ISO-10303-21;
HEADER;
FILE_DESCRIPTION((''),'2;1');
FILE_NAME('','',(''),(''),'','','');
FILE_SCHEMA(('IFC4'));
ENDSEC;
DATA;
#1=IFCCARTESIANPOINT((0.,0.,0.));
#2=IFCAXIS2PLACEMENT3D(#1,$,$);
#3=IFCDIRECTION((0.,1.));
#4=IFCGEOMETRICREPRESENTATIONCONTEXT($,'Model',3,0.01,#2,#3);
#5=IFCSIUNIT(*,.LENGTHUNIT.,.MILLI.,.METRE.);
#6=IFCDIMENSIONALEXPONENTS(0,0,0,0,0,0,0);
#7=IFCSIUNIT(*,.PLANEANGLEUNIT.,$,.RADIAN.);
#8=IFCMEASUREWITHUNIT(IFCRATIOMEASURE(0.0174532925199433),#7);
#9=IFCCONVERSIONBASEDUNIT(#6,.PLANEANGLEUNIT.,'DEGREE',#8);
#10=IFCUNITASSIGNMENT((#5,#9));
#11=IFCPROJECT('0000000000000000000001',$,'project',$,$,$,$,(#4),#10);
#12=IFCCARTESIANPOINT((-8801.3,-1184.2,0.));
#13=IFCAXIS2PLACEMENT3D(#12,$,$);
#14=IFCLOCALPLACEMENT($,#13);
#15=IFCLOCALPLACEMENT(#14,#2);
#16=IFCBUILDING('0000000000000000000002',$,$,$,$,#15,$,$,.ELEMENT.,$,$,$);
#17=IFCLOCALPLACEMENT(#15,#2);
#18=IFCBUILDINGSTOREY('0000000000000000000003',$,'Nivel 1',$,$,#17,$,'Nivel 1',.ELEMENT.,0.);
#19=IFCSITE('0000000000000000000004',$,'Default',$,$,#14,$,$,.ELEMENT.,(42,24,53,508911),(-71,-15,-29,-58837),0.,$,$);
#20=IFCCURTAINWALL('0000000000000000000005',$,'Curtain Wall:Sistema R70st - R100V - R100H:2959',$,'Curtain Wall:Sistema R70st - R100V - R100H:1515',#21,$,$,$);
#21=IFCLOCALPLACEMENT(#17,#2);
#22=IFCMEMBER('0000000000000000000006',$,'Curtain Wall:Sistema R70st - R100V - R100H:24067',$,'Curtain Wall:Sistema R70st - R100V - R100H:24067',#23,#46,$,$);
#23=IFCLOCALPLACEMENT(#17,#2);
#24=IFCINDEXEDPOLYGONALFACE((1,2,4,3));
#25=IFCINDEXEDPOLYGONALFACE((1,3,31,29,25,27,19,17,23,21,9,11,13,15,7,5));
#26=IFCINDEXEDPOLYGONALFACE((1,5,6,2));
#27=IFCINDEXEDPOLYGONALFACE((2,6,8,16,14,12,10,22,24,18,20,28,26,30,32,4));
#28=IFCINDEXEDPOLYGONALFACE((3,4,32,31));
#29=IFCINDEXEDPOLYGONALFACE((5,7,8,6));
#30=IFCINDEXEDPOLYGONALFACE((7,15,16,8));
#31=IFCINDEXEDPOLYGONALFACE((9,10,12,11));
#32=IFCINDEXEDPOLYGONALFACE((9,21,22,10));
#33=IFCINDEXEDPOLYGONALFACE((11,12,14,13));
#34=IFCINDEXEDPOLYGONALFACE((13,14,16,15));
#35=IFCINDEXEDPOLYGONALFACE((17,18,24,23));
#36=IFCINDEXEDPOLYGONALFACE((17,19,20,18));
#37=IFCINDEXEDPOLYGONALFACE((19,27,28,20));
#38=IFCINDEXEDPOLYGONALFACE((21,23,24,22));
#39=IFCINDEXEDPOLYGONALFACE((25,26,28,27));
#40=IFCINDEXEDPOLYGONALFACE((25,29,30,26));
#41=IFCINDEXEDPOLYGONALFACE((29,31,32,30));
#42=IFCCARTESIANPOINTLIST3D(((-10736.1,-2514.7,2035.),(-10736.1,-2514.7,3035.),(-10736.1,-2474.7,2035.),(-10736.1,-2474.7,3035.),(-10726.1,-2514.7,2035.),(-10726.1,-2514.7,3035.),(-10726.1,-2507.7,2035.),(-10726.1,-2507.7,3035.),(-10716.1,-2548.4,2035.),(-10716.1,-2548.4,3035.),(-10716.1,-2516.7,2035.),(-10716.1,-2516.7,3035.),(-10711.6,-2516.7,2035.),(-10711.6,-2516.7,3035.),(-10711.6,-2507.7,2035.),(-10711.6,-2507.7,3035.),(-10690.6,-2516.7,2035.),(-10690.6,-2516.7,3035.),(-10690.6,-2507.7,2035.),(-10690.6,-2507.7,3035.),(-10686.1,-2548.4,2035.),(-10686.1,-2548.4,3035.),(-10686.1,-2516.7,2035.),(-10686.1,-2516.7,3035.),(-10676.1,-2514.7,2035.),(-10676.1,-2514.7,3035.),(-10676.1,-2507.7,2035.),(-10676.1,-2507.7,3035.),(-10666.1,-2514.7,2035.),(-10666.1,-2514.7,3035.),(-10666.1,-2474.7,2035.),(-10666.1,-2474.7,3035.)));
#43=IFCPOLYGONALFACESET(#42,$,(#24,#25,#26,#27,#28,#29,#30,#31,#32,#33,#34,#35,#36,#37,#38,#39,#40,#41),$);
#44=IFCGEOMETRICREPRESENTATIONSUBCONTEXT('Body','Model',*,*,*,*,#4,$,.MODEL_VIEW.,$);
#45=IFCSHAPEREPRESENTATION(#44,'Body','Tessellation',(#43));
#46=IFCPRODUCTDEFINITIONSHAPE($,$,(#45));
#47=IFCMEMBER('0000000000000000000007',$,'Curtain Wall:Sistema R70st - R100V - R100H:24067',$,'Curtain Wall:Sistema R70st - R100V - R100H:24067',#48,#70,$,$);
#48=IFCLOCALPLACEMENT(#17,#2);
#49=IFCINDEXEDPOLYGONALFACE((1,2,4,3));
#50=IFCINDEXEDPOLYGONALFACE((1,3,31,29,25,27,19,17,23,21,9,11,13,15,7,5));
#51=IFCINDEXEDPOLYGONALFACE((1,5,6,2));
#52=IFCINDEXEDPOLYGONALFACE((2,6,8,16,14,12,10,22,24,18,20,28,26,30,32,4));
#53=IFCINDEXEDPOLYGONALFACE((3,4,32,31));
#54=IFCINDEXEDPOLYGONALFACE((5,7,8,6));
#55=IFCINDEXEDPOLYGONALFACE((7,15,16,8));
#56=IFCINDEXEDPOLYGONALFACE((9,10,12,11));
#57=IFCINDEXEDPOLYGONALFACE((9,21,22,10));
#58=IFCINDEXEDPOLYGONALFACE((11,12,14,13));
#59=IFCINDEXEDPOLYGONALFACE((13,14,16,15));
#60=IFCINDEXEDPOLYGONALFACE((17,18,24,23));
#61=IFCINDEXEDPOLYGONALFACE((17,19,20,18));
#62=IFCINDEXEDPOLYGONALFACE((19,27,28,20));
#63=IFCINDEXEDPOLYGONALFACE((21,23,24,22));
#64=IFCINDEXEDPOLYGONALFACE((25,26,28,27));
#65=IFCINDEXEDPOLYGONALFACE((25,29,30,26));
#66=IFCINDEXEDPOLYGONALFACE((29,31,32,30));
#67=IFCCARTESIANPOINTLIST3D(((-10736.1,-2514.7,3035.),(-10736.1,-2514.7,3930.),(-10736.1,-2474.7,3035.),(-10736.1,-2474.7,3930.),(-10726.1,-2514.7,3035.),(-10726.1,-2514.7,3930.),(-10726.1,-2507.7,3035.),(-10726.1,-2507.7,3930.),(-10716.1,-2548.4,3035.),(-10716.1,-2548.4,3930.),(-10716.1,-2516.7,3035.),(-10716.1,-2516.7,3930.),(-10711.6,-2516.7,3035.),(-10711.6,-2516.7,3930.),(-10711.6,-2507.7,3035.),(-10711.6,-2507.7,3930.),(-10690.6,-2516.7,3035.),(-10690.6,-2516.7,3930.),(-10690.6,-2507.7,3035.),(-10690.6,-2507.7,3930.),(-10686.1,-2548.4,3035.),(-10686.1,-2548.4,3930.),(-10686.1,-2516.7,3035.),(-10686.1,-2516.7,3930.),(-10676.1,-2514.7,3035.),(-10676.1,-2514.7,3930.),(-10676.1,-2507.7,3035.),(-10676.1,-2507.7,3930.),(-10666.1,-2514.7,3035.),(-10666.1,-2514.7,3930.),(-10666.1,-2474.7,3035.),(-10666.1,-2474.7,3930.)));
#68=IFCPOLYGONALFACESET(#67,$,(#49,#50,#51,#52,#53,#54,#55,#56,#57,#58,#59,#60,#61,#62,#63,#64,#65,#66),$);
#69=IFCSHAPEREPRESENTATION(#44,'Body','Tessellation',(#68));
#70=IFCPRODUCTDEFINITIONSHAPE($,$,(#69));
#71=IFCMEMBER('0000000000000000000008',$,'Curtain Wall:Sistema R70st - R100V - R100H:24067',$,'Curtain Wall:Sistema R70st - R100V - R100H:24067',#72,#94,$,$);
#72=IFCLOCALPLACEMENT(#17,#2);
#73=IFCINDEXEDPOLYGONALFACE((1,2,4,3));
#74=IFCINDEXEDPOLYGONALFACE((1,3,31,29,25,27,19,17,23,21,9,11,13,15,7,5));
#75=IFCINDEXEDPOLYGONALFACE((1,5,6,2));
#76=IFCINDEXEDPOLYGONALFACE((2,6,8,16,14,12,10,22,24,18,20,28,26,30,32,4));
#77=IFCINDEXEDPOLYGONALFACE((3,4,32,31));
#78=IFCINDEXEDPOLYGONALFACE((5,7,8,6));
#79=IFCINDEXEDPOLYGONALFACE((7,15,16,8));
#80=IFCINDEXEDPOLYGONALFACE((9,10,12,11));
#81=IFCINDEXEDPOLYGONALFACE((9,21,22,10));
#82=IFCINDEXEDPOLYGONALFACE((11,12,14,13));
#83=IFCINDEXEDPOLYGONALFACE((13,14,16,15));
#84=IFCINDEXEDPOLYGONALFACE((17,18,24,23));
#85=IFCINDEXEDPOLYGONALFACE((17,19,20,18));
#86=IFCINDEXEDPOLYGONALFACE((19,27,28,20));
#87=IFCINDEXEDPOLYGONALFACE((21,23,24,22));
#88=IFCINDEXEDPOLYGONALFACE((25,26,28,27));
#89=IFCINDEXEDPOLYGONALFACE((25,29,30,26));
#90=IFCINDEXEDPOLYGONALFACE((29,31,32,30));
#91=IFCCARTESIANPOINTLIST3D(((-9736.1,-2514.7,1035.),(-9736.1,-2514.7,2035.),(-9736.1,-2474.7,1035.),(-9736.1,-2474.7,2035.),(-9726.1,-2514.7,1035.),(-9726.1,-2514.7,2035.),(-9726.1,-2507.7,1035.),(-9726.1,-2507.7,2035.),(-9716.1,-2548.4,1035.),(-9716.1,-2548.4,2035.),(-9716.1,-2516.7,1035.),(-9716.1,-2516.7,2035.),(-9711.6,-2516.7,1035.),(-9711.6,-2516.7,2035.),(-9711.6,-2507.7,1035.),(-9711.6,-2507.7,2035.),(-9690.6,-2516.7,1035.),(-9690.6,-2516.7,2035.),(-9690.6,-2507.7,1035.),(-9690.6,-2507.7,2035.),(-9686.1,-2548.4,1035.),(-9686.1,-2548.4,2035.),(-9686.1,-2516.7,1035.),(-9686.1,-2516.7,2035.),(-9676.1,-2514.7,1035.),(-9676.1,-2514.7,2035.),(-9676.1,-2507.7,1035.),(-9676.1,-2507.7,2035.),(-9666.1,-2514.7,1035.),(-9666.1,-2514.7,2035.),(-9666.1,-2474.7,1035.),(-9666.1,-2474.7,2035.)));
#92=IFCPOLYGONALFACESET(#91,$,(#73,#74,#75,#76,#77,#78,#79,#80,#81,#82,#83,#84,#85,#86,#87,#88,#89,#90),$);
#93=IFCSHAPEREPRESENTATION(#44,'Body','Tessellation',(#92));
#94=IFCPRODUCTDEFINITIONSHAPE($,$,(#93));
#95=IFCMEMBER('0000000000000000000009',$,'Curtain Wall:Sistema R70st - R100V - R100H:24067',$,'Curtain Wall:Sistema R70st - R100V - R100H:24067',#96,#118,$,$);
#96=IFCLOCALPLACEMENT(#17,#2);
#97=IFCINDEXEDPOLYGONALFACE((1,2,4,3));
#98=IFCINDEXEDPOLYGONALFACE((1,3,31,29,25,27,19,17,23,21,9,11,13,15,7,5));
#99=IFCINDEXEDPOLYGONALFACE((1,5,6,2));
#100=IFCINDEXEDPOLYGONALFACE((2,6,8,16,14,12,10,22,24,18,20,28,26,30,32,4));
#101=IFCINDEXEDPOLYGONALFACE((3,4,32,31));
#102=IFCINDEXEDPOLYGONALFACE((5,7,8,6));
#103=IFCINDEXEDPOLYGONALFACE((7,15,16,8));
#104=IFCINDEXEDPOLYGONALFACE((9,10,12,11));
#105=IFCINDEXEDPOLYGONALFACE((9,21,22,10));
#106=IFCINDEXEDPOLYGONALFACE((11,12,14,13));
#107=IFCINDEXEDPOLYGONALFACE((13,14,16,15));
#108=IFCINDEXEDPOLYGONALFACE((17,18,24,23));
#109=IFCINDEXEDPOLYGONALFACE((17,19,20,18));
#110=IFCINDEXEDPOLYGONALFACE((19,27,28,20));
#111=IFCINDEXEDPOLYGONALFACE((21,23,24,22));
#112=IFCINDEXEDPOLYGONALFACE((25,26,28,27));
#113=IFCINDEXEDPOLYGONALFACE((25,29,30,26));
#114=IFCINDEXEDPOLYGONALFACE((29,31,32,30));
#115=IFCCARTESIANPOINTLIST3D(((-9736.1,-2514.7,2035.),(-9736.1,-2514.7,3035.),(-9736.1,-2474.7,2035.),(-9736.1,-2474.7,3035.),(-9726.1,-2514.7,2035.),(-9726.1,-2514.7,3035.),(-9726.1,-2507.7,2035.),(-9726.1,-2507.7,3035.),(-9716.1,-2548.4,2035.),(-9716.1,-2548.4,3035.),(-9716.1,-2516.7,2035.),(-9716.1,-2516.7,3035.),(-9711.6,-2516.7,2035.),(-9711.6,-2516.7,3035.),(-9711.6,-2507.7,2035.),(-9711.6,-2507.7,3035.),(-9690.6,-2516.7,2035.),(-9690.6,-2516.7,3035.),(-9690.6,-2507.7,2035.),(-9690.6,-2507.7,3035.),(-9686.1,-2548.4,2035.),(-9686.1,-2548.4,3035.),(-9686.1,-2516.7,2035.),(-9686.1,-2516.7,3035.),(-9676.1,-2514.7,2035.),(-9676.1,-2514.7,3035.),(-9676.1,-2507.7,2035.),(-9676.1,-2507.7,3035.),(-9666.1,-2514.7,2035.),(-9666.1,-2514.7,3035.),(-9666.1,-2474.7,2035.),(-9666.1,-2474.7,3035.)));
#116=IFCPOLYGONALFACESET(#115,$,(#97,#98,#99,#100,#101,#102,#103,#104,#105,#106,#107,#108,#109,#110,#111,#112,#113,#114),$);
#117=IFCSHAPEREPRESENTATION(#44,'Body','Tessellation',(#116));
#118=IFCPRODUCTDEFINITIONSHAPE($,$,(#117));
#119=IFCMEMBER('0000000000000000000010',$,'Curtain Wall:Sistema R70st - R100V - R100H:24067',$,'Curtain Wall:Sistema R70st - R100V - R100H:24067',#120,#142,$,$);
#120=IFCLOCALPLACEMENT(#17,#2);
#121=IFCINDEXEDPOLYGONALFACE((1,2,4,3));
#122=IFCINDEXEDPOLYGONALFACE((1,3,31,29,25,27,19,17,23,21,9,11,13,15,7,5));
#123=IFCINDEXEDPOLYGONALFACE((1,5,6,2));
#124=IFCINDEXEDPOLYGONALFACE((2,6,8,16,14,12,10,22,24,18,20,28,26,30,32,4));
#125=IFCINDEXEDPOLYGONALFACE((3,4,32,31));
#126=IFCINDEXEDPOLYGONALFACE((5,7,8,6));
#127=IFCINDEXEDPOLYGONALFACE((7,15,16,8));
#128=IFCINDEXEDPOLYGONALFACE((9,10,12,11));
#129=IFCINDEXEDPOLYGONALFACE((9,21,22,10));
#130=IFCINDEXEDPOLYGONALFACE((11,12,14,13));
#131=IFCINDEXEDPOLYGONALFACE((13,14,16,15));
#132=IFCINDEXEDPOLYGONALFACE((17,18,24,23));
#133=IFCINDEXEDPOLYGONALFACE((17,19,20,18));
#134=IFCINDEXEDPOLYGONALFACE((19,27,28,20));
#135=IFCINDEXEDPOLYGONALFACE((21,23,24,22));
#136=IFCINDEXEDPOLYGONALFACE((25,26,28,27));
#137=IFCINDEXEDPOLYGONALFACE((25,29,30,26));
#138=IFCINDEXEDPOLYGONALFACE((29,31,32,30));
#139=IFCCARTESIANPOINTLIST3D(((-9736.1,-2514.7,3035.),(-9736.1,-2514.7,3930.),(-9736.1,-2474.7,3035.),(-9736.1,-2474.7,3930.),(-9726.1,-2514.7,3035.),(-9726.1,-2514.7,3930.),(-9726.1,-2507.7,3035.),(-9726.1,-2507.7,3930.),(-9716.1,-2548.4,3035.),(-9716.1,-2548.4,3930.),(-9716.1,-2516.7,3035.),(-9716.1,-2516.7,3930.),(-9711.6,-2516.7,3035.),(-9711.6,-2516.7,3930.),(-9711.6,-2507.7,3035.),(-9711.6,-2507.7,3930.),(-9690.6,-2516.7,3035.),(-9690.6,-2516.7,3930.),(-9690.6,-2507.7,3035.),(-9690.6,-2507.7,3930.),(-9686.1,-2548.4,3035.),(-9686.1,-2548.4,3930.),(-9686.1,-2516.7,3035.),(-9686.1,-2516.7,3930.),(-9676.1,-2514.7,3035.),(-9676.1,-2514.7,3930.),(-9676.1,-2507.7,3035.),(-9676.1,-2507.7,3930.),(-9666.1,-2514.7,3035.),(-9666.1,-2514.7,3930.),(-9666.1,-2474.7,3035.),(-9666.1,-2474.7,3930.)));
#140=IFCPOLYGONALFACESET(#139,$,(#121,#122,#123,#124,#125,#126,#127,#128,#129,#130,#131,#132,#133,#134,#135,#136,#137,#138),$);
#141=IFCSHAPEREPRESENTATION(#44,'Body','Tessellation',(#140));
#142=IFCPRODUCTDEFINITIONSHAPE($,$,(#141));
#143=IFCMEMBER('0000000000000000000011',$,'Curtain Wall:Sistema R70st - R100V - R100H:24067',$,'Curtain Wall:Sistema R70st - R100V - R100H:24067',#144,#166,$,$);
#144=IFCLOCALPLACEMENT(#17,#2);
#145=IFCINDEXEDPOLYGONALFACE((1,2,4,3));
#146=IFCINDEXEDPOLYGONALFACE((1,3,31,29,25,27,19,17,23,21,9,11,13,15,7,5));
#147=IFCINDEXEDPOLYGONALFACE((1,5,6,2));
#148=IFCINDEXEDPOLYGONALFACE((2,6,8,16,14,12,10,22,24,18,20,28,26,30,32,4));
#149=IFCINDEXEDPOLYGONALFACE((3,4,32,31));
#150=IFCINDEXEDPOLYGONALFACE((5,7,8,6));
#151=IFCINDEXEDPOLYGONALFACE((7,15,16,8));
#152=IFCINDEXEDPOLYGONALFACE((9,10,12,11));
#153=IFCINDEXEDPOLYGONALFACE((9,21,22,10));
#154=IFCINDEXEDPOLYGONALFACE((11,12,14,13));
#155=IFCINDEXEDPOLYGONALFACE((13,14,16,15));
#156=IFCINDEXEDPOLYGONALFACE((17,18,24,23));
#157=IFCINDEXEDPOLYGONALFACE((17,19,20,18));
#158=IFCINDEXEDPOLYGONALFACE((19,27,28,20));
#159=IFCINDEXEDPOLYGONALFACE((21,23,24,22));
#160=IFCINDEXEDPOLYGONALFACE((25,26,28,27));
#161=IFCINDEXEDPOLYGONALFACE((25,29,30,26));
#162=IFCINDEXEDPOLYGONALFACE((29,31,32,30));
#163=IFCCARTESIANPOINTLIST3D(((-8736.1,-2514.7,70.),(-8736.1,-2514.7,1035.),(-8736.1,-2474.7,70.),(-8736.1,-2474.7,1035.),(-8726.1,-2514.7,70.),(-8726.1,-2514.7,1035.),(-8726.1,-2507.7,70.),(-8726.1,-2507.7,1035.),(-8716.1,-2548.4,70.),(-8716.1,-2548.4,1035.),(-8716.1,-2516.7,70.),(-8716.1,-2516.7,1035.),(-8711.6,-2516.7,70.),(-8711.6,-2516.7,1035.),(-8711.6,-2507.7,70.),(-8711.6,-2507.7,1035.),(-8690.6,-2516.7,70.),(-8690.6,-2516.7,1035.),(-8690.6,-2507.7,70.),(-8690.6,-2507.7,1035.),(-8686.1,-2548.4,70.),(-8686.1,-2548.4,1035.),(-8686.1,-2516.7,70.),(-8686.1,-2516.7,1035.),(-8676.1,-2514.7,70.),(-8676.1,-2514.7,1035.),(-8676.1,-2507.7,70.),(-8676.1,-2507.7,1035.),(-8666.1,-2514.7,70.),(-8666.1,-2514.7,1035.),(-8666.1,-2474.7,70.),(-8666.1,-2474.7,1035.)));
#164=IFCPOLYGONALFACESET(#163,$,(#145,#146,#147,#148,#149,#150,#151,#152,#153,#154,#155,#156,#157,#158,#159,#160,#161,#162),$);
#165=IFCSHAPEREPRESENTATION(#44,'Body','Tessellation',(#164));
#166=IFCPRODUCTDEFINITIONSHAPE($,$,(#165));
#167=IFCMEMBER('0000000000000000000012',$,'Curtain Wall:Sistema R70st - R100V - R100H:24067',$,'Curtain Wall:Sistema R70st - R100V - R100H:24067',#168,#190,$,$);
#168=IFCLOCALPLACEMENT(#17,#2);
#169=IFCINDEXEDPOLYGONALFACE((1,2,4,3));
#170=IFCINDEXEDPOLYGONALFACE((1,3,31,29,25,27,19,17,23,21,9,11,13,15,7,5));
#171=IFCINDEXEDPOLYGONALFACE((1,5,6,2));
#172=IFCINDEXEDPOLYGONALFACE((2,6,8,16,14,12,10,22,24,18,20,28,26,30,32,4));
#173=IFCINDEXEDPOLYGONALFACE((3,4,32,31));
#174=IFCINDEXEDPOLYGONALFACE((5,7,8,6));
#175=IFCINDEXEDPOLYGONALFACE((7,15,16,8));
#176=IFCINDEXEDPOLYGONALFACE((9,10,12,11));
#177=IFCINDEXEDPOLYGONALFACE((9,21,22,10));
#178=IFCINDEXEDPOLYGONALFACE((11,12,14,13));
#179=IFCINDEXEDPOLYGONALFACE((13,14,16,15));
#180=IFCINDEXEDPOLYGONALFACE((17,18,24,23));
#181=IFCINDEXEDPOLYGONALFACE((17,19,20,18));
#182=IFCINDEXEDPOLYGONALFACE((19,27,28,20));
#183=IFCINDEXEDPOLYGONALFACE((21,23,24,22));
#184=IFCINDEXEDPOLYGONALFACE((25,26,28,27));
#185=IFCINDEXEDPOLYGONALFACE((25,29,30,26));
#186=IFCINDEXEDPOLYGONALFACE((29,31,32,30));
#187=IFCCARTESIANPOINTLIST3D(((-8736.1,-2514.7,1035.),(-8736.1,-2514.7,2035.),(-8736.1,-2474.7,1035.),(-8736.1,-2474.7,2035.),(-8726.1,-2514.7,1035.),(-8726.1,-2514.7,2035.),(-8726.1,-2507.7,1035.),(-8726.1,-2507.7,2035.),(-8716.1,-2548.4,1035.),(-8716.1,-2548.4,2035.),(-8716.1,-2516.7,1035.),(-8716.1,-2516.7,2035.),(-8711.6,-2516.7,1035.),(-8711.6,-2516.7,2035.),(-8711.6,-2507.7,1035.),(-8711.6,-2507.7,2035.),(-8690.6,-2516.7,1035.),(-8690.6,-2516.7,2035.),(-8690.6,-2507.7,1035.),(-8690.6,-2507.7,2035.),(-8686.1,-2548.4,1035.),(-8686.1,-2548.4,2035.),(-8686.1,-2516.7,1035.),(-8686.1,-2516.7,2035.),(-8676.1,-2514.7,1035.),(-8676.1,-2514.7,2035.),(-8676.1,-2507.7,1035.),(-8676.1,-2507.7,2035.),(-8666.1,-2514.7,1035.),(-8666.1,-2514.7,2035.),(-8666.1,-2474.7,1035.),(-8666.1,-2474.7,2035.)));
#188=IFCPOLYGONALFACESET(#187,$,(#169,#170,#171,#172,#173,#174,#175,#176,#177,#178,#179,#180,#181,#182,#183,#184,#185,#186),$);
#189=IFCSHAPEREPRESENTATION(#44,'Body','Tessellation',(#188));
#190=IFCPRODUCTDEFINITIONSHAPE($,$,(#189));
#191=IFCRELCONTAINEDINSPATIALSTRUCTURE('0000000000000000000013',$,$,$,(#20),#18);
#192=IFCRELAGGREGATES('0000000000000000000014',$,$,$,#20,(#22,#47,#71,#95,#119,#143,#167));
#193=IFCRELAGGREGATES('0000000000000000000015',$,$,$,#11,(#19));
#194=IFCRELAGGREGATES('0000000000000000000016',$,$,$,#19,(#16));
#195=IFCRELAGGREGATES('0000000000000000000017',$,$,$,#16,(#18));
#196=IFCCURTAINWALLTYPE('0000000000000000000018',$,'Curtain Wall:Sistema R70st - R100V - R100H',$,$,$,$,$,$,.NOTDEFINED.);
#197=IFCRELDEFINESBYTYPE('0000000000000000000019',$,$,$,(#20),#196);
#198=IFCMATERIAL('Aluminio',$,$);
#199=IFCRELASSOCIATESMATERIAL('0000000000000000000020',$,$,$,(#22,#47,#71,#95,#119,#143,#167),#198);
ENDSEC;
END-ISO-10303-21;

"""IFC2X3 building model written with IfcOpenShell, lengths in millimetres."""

from ifc_helpers import new_model, entity, si_unit, converted_unit, direction, frame, origin, place, context, subcontext, project, spatial, polyline, outline, extrude, material, type_object, element, aggregate, save


model = new_model("IFC2X3")

# Units and contexts
model_context = context("Model", 3, precision=0.01, world=origin(), true_north=direction((0.0, 1.0)))
body_context = subcontext(model_context, "Body", "Model", "MODEL_VIEW")
ifc_project = project(units=[si_unit("LENGTHUNIT", "METRE", prefix="MILLI"), converted_unit("PLANEANGLEUNIT", "DEGREE", entity("IfcRatioMeasure", 0.0174532925199433), si_unit("PLANEANGLEUNIT", "RADIAN"), dimensions=[0, 0, 0, 0, 0, 0, 0])], contexts=[model_context])

# Site, building, storey
site_placement = place(None, frame((-8801.3, -1184.2, 0.0)))
site = spatial("IfcSite", under=ifc_project, at=site_placement, Name="Default", CompositionType="ELEMENT", RefLatitude=(42, 24, 53, 508911), RefLongitude=(-71, -15, -29, -58837), RefElevation=0.0)
building_placement = place(site_placement, origin())
building = spatial("IfcBuilding", under=site, at=building_placement, CompositionType="ELEMENT")
storey_placement = place(building_placement, origin())
storey = spatial("IfcBuildingStorey", under=building, at=storey_placement, Name="Nivel 1", LongName="Nivel 1", CompositionType="ELEMENT", Elevation=0.0)

# Curtain wall, members
curtain_wall_type = type_object("IfcCurtainWallType", Name="Curtain Wall:Sistema R70st - R100V - R100H", PredefinedType="NOTDEFINED")
curtain_wall_placement = place(storey_placement, origin())
curtain_wall = element("IfcCurtainWall", 1, at=curtain_wall_placement, inside=storey, type_object=curtain_wall_type, Name="Curtain Wall:Sistema R70st - R100V - R100H:2959", ObjectType="Curtain Wall:Sistema R70st - R100V - R100H:1515")
ifc_material = material(Name="Aluminio")
member_1_placement = place(curtain_wall_placement, origin())
member_1 = element("IfcMember", 2, at=member_1_placement, material=ifc_material, Name="Curtain Wall:Sistema R70st - R100V - R100H:24067", ObjectType="Curtain Wall:Sistema R70st - R100V - R100H:24067", context=body_context, shape_type="SweptSolid", body=[
    extrude(outline(polyline([(-35.0, -38.0), (35.0, -38.0), (35.0, 2.0), (25.0, 2.0), (25.0, -5.0), (10.5, -5.0), (10.5, 4.0), (15.0, 4.0), (15.0, 35.7), (-15.0, 35.7), (-15.0, 4.0), (-10.5, 4.0), (-10.5, -5.0), (-25.0, -5.0), (-25.0, 2.0), (-35.0, 2.0), (-35.0, -38.0)])), frame((-10701.1, -2512.7, 2035.0), z_axis=(0.0, 0.0, 1.0), x_axis=(-1.0, 0.0, 0.0)), (0.0, 0.0, 1.0), 1000.0),
])
member_2_placement = place(curtain_wall_placement, origin())
member_2 = element("IfcMember", 3, at=member_2_placement, material=ifc_material, Name="Curtain Wall:Sistema R70st - R100V - R100H:24067", ObjectType="Curtain Wall:Sistema R70st - R100V - R100H:24067", context=body_context, shape_type="SweptSolid", body=[
    extrude(outline(polyline([(-35.0, -38.0), (35.0, -38.0), (35.0, 2.0), (25.0, 2.0), (25.0, -5.0), (10.5, -5.0), (10.5, 4.0), (15.0, 4.0), (15.0, 35.7), (-15.0, 35.7), (-15.0, 4.0), (-10.5, 4.0), (-10.5, -5.0), (-25.0, -5.0), (-25.0, 2.0), (-35.0, 2.0), (-35.0, -38.0)])), frame((-10701.1, -2512.7, 3035.0), z_axis=(0.0, 0.0, 1.0), x_axis=(-1.0, 0.0, 0.0)), (0.0, 0.0, 1.0), 895.0),
])
member_3_placement = place(curtain_wall_placement, origin())
member_3 = element("IfcMember", 4, at=member_3_placement, material=ifc_material, Name="Curtain Wall:Sistema R70st - R100V - R100H:24067", ObjectType="Curtain Wall:Sistema R70st - R100V - R100H:24067", context=body_context, shape_type="SweptSolid", body=[
    extrude(outline(polyline([(-35.0, -38.0), (35.0, -38.0), (35.0, 2.0), (25.0, 2.0), (25.0, -5.0), (10.5, -5.0), (10.5, 4.0), (15.0, 4.0), (15.0, 35.7), (-15.0, 35.7), (-15.0, 4.0), (-10.5, 4.0), (-10.5, -5.0), (-25.0, -5.0), (-25.0, 2.0), (-35.0, 2.0), (-35.0, -38.0)])), frame((-9701.1, -2512.7, 1035.0), z_axis=(0.0, 0.0, 1.0), x_axis=(-1.0, 0.0, 0.0)), (0.0, 0.0, 1.0), 1000.0),
])
member_4_placement = place(curtain_wall_placement, origin())
member_4 = element("IfcMember", 5, at=member_4_placement, material=ifc_material, Name="Curtain Wall:Sistema R70st - R100V - R100H:24067", ObjectType="Curtain Wall:Sistema R70st - R100V - R100H:24067", context=body_context, shape_type="SweptSolid", body=[
    extrude(outline(polyline([(-35.0, -38.0), (35.0, -38.0), (35.0, 2.0), (25.0, 2.0), (25.0, -5.0), (10.5, -5.0), (10.5, 4.0), (15.0, 4.0), (15.0, 35.7), (-15.0, 35.7), (-15.0, 4.0), (-10.5, 4.0), (-10.5, -5.0), (-25.0, -5.0), (-25.0, 2.0), (-35.0, 2.0), (-35.0, -38.0)])), frame((-9701.1, -2512.7, 2035.0), z_axis=(0.0, 0.0, 1.0), x_axis=(-1.0, 0.0, 0.0)), (0.0, 0.0, 1.0), 1000.0),
])
member_5_placement = place(curtain_wall_placement, origin())
member_5 = element("IfcMember", 6, at=member_5_placement, material=ifc_material, Name="Curtain Wall:Sistema R70st - R100V - R100H:24067", ObjectType="Curtain Wall:Sistema R70st - R100V - R100H:24067", context=body_context, shape_type="SweptSolid", body=[
    extrude(outline(polyline([(-35.0, -38.0), (35.0, -38.0), (35.0, 2.0), (25.0, 2.0), (25.0, -5.0), (10.5, -5.0), (10.5, 4.0), (15.0, 4.0), (15.0, 35.7), (-15.0, 35.7), (-15.0, 4.0), (-10.5, 4.0), (-10.5, -5.0), (-25.0, -5.0), (-25.0, 2.0), (-35.0, 2.0), (-35.0, -38.0)])), frame((-9701.1, -2512.7, 3035.0), z_axis=(0.0, 0.0, 1.0), x_axis=(-1.0, 0.0, 0.0)), (0.0, 0.0, 1.0), 895.0),
])
member_6_placement = place(curtain_wall_placement, origin())
member_6 = element("IfcMember", 7, at=member_6_placement, material=ifc_material, Name="Curtain Wall:Sistema R70st - R100V - R100H:24067", ObjectType="Curtain Wall:Sistema R70st - R100V - R100H:24067", context=body_context, shape_type="SweptSolid", body=[
    extrude(outline(polyline([(-35.0, -38.0), (35.0, -38.0), (35.0, 2.0), (25.0, 2.0), (25.0, -5.0), (10.5, -5.0), (10.5, 4.0), (15.0, 4.0), (15.0, 35.7), (-15.0, 35.7), (-15.0, 4.0), (-10.5, 4.0), (-10.5, -5.0), (-25.0, -5.0), (-25.0, 2.0), (-35.0, 2.0), (-35.0, -38.0)])), frame((-8701.1, -2512.7, 70.0), z_axis=(0.0, 0.0, 1.0), x_axis=(-1.0, 0.0, 0.0)), (0.0, 0.0, 1.0), 965.0),
])
member_7_placement = place(curtain_wall_placement, origin())
member_7 = element("IfcMember", 8, at=member_7_placement, material=ifc_material, Name="Curtain Wall:Sistema R70st - R100V - R100H:24067", ObjectType="Curtain Wall:Sistema R70st - R100V - R100H:24067", context=body_context, shape_type="SweptSolid", body=[
    extrude(outline(polyline([(-35.0, -38.0), (35.0, -38.0), (35.0, 2.0), (25.0, 2.0), (25.0, -5.0), (10.5, -5.0), (10.5, 4.0), (15.0, 4.0), (15.0, 35.7), (-15.0, 35.7), (-15.0, 4.0), (-10.5, 4.0), (-10.5, -5.0), (-25.0, -5.0), (-25.0, 2.0), (-35.0, 2.0), (-35.0, -38.0)])), frame((-8701.1, -2512.7, 1035.0), z_axis=(0.0, 0.0, 1.0), x_axis=(-1.0, 0.0, 0.0)), (0.0, 0.0, 1.0), 1000.0),
])
aggregate(curtain_wall, [member_1, member_2, member_3, member_4, member_5, member_6, member_7])

save(model, "model.ifc")
